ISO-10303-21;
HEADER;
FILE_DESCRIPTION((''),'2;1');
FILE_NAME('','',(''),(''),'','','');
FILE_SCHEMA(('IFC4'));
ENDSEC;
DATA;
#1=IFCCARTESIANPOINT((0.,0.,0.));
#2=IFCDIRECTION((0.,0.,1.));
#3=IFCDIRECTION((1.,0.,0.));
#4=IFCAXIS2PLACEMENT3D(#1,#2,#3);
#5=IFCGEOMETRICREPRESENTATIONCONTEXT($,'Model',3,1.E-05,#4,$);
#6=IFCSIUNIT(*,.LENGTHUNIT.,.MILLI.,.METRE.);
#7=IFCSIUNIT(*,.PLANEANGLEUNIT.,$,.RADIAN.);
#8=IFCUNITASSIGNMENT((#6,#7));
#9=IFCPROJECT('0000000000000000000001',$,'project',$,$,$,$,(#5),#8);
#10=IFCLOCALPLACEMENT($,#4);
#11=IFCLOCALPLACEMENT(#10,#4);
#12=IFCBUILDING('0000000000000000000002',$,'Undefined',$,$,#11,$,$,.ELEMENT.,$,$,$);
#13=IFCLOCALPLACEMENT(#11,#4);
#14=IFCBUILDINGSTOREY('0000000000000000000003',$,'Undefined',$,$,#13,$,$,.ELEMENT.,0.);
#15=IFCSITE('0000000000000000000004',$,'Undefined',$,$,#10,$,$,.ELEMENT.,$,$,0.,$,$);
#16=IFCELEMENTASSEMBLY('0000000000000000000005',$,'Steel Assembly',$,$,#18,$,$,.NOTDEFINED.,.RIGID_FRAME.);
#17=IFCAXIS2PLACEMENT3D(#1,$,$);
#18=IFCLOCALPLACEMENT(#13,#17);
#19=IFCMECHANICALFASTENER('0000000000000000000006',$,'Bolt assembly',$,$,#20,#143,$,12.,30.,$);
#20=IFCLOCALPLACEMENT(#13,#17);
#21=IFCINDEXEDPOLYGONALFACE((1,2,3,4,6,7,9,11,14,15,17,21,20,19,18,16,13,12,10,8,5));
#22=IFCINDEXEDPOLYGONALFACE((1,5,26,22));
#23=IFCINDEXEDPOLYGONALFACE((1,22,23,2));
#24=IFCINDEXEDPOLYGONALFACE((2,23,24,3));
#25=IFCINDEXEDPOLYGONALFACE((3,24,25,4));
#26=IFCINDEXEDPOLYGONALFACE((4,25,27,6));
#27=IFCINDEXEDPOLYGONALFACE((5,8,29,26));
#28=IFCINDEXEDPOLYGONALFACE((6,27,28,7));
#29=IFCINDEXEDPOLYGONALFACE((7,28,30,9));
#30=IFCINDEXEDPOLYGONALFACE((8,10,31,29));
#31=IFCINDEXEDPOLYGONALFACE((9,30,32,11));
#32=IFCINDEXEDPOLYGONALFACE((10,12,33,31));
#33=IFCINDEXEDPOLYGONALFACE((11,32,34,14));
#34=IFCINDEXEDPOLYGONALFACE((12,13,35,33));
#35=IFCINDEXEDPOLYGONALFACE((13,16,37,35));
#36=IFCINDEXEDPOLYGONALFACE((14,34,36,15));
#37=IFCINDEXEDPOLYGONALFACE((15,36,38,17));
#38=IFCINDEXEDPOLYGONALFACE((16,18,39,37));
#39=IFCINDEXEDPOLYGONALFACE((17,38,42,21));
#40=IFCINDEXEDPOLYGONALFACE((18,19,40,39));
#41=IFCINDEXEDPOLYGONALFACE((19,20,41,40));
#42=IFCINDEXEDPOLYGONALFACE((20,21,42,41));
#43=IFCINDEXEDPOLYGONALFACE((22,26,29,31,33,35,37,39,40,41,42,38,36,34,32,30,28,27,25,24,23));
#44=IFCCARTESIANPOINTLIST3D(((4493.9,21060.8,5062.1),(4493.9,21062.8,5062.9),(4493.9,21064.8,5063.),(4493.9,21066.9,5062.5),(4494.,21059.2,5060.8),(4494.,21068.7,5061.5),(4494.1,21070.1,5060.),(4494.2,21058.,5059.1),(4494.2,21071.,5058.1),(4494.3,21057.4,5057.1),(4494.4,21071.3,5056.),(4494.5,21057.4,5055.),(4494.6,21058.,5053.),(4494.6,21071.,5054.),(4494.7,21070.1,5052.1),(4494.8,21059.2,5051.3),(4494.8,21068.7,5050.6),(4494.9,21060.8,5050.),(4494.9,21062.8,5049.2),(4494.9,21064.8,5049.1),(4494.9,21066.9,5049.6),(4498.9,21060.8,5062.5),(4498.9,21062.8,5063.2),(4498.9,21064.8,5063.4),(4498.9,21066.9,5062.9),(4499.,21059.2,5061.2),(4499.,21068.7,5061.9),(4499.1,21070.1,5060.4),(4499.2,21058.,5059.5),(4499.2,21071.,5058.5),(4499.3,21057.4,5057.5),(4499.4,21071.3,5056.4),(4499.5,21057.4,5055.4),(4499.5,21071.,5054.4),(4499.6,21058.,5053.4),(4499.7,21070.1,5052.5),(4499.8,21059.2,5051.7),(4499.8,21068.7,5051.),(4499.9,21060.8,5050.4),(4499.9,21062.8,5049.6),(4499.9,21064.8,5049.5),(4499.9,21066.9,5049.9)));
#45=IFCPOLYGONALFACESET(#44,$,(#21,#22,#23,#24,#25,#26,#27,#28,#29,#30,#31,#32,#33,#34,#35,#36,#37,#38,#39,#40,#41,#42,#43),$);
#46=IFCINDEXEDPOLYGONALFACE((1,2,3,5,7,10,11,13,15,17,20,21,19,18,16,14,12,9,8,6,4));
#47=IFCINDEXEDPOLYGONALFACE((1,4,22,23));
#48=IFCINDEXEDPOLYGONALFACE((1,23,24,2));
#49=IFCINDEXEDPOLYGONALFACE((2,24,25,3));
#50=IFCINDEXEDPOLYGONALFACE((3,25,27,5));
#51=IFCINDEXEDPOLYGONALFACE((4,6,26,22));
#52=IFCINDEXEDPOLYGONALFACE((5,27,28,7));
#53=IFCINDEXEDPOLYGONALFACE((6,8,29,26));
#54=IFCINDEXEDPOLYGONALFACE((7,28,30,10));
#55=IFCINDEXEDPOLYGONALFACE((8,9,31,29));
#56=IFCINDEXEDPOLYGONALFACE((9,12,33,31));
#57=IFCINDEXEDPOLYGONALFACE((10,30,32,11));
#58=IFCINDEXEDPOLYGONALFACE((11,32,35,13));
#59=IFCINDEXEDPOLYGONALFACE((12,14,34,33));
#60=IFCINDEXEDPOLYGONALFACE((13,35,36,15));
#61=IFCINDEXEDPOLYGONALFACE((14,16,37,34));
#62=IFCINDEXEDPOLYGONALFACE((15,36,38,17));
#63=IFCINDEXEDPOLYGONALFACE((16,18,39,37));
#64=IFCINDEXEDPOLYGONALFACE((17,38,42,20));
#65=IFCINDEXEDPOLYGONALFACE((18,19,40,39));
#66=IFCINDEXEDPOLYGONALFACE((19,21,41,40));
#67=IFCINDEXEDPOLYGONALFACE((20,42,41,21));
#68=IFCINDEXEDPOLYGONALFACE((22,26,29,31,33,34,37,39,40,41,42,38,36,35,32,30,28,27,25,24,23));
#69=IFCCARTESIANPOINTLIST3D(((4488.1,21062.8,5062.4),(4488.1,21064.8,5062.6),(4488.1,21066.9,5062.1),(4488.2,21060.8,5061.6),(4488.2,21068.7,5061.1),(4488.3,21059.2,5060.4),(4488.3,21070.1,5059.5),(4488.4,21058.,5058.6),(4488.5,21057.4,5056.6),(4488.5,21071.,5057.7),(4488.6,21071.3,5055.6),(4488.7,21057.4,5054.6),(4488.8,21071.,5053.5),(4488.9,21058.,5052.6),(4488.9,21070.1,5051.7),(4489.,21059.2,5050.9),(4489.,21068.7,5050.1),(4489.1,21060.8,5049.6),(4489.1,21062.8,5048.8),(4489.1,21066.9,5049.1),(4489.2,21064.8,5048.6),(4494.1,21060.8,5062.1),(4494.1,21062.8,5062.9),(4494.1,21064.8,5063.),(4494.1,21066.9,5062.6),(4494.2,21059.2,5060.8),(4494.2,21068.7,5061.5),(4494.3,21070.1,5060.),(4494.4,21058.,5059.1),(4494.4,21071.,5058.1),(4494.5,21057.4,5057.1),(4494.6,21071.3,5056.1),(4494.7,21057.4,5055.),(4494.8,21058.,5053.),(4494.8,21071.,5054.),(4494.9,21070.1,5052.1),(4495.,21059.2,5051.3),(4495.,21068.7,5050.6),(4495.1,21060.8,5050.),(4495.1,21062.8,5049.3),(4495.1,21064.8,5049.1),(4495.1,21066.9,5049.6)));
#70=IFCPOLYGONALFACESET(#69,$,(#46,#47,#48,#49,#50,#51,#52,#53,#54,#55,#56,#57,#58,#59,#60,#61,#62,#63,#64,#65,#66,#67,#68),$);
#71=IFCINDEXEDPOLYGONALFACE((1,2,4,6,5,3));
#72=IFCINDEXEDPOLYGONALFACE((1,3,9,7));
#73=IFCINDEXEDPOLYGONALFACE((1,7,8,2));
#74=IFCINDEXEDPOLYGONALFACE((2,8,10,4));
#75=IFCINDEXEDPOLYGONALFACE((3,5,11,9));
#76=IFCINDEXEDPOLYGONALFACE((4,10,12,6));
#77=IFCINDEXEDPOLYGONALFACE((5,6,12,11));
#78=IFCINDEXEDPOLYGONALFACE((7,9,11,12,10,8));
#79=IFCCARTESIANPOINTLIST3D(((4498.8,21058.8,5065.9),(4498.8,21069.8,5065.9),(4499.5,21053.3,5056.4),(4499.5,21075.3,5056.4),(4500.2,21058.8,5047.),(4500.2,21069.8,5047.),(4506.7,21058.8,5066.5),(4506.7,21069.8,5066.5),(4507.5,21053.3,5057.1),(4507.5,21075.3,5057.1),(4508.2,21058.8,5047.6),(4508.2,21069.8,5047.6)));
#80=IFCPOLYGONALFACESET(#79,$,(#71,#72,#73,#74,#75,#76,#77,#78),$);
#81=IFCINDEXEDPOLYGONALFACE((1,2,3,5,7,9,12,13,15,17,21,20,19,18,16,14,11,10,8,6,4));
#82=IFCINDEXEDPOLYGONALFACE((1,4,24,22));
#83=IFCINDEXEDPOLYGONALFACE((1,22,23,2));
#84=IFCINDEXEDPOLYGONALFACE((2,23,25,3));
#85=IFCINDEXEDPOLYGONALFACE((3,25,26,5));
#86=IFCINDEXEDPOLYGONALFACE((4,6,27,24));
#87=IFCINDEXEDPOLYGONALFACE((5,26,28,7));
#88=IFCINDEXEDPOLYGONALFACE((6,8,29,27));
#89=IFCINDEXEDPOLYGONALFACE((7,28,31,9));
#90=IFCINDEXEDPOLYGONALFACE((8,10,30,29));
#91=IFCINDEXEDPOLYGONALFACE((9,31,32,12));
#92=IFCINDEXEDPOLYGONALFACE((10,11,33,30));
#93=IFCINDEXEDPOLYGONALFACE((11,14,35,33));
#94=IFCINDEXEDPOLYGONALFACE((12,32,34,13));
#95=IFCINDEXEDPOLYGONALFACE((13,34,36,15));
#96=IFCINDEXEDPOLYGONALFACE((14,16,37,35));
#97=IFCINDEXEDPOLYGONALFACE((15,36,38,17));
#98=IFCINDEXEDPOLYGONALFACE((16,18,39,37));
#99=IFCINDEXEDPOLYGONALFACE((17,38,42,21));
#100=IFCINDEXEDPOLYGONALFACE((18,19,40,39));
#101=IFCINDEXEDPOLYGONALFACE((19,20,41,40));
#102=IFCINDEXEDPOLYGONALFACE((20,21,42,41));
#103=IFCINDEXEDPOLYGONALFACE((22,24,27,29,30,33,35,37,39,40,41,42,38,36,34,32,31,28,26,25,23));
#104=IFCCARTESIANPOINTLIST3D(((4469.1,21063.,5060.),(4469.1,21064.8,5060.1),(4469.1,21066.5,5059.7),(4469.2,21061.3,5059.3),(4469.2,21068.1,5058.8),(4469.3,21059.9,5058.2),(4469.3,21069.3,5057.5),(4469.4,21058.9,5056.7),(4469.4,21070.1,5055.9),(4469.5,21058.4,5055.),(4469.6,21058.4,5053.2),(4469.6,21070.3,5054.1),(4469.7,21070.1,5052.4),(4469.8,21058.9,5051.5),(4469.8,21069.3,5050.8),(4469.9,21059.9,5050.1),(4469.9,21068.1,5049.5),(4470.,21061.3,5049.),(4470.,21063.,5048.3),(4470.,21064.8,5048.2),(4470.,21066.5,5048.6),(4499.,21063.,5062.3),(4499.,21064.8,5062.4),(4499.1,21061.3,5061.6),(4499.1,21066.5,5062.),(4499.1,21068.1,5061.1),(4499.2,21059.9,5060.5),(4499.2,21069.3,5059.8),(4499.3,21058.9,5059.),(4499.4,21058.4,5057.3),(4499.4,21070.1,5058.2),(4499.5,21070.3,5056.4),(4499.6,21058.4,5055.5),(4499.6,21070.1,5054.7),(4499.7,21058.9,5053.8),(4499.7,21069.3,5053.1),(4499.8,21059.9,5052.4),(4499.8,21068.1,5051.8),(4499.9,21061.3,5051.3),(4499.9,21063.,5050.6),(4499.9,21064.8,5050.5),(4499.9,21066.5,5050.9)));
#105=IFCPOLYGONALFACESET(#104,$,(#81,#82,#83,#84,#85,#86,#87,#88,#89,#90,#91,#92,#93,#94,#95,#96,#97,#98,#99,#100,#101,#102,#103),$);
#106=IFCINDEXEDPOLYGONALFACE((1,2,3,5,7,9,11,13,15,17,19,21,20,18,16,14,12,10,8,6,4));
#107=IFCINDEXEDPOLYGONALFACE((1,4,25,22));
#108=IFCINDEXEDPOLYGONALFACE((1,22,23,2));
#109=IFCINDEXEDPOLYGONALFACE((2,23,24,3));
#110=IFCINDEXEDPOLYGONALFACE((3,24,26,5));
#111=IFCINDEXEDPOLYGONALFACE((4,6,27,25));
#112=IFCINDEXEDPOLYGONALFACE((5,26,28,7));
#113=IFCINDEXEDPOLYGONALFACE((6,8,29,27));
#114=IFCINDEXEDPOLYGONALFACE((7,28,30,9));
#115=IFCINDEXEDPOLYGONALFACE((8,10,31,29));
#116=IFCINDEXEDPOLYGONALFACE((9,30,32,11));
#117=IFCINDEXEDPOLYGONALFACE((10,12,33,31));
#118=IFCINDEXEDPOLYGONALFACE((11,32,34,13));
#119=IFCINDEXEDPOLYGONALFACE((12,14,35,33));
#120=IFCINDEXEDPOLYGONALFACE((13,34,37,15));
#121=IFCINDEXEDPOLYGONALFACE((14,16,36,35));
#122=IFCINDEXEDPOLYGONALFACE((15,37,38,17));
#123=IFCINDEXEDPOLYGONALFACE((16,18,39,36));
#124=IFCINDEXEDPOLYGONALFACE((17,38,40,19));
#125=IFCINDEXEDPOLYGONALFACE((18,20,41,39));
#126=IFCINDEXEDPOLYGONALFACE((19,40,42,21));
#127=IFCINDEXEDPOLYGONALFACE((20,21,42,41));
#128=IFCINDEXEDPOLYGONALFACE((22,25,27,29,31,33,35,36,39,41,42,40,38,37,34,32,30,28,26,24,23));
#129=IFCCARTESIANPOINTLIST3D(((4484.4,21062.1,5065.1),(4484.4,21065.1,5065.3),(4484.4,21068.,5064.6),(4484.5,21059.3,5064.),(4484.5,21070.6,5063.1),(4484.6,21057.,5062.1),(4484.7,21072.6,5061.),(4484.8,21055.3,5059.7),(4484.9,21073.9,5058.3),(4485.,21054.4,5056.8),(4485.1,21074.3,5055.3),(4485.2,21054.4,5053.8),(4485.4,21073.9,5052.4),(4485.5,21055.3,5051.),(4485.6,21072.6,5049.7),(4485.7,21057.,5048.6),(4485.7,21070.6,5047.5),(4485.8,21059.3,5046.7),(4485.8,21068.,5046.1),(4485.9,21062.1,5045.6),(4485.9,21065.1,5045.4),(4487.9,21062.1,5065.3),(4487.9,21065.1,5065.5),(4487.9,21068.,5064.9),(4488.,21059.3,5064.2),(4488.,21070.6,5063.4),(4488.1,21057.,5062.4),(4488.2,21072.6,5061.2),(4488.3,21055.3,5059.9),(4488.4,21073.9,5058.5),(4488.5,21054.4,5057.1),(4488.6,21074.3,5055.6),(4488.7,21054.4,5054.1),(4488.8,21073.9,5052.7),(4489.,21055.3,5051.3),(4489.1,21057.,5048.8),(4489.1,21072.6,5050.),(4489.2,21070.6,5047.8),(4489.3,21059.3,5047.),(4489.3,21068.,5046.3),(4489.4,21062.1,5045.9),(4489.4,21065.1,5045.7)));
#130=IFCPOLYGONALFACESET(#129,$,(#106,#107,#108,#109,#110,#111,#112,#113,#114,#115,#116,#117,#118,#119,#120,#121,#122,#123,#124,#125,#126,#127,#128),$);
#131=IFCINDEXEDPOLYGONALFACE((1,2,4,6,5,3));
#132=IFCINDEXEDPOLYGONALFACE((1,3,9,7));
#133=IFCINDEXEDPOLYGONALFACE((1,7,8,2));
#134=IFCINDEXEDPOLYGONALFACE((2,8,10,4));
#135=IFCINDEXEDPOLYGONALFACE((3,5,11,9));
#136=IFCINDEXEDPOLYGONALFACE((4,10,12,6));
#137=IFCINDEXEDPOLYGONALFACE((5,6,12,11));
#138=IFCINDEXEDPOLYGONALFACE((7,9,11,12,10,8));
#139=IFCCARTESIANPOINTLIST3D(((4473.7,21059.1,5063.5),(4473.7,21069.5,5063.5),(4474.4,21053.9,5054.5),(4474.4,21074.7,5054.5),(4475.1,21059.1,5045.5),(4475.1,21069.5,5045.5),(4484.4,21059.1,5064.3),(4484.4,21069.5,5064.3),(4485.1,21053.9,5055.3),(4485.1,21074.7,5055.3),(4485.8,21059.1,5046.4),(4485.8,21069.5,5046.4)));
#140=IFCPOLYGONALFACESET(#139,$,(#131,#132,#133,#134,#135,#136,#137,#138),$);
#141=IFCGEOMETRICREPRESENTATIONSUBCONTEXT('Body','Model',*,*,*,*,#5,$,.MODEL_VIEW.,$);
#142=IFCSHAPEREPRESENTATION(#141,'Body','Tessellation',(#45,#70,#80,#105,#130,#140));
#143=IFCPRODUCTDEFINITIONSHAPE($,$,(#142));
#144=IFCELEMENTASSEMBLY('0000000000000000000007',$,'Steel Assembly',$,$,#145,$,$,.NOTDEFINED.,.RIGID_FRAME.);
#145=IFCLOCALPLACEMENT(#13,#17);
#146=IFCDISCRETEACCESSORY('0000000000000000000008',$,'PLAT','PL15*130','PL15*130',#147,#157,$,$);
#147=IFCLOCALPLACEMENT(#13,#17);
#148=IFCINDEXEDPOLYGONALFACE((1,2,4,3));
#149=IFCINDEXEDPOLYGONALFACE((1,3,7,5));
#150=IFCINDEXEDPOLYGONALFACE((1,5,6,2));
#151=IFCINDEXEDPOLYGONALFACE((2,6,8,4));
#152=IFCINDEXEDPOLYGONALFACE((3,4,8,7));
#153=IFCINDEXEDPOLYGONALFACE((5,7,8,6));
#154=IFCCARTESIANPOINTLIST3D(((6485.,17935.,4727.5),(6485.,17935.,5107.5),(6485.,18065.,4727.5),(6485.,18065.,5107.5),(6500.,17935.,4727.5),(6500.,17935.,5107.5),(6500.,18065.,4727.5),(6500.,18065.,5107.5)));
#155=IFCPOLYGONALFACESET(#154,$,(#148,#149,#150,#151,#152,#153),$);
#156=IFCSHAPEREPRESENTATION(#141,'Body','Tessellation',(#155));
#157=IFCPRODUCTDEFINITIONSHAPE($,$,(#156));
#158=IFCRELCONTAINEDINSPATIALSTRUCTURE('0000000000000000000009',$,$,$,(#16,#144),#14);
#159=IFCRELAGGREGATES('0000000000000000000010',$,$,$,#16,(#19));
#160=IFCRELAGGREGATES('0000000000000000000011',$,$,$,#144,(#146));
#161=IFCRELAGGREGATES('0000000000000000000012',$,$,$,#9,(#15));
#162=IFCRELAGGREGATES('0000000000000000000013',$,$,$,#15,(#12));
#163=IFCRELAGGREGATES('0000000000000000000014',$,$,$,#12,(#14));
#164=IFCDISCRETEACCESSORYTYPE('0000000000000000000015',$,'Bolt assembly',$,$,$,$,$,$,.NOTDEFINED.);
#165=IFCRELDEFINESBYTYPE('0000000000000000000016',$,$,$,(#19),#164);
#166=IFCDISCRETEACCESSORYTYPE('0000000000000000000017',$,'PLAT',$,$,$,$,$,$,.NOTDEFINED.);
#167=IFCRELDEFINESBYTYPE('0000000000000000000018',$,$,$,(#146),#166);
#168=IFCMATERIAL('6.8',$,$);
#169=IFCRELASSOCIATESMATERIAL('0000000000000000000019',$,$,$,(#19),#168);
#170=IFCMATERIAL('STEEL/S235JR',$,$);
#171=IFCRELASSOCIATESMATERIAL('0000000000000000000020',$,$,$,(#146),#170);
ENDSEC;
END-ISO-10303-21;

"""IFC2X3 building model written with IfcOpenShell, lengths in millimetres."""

from ifc_helpers import new_model, si_unit, frame, origin_with_axes, origin_2d_with_axis, place, context, subcontext, project, spatial, polyline, circle, outline, extrude, source, transform, mapped, material, type_object, element, aggregate, save


model = new_model("IFC2X3")

# Units and contexts
model_context = context("Model", 3, precision=1e-05, world=origin_with_axes())
body_context = subcontext(model_context, "Body", "Model", "MODEL_VIEW")
ifc_project = project(units=[si_unit("LENGTHUNIT", "METRE", prefix="MILLI"), si_unit("PLANEANGLEUNIT", "RADIAN")], contexts=[model_context])

# Site, building, storey
site_placement = place(None, origin_with_axes())
site = spatial("IfcSite", under=ifc_project, at=site_placement, Name="Undefined", CompositionType="ELEMENT", RefElevation=0.0)
building_placement = place(site_placement, origin_with_axes())
building = spatial("IfcBuilding", under=site, at=building_placement, Name="Undefined", CompositionType="ELEMENT")
storey_placement = place(building_placement, origin_with_axes())
storey = spatial("IfcBuildingStorey", under=building, at=storey_placement, Name="Undefined", CompositionType="ELEMENT", Elevation=0.0)

# Shared definitions
ifc_material_1 = material(Name="STEEL/S235JR")

# Shared definitions
ifc_material_2 = material(Name="6.8")
discrete_accessory_type_1 = type_object("IfcDiscreteAccessoryType", Name="Bolt assembly")

# Element assembly, mechanical fastener
assembly_1_placement = place(storey_placement, origin_with_axes())
assembly_1 = element("IfcElementAssembly", 1, at=assembly_1_placement, inside=storey, Name="Steel Assembly", AssemblyPlace="NOTDEFINED", PredefinedType="RIGID_FRAME")
shared_shape_1 = source(origin_with_axes(), body_context, "Body", "SweptSolid", [
    extrude(circle(Radius=7.0, at=origin_2d_with_axis()), frame((0.0, -4.9, 0.0), z_axis=(0.0, 1.0, 0.0), x_axis=(1.0, 0.0, 0.0)), (0.0, 0.0, 1.0), 5.0),
    extrude(circle(Radius=7.0, at=origin_2d_with_axis()), frame((0.0, -0.1, 0.0), z_axis=(0.0, 1.0, 0.0), x_axis=(1.0, 0.0, 0.0)), (0.0, 0.0, 1.0), 6.0),
    extrude(outline(polyline([(11.0, 0.0), (5.5, 9.5), (-5.5, 9.5), (-11.0, 0.0), (-5.5, -9.5), (5.5, -9.5), (11.0, 0.0)])), frame((0.0, -13.0, 0.0), z_axis=(0.0, 1.0, 0.0), x_axis=(1.0, 0.0, 0.0)), (0.0, 0.0, 1.0), 8.0),
    extrude(circle(Radius=6.0, at=origin_2d_with_axis()), frame((0.0, -5.0, 0.0), z_axis=(0.0, 1.0, 0.0), x_axis=(1.0, 0.0, 0.0)), (0.0, 0.0, 1.0), 30.0),
    extrude(circle(Radius=10.0, at=origin_2d_with_axis()), frame((0.0, 5.9, 0.0), z_axis=(0.0, 1.0, 0.0), x_axis=(1.0, 0.0, 0.0)), (0.0, 0.0, 1.0), 3.5),
    extrude(outline(polyline([(10.4, 0.0), (5.2, 9.0), (-5.2, 9.0), (-10.4, 0.0), (-5.2, -9.0), (5.2, -9.0), (10.4, 0.0)])), frame((0.0, 9.4, 0.0), z_axis=(0.0, 1.0, 0.0), x_axis=(1.0, 0.0, 0.0)), (0.0, 0.0, 1.0), 10.8),
])
mechanical_fastener_1_placement = place(assembly_1_placement, frame((4494.5, 21064.3, 5056.1), z_axis=(-0.076696, 0.0, 0.997054), x_axis=(0.0, 1.0, 0.0)))
mechanical_fastener_1 = element("IfcMechanicalFastener", 2, at=mechanical_fastener_1_placement, type_object=discrete_accessory_type_1, material=ifc_material_2, Name="Bolt assembly", NominalDiameter=12.0, NominalLength=30.0, context=body_context, shape_type="MappedRepresentation", body=[
    mapped(shared_shape_1, transform((0.0, 0.0, 0.0))),
])
aggregate(assembly_1, [mechanical_fastener_1])

# Element assembly, discrete accessory
assembly_2_placement = place(storey_placement, origin_with_axes())
assembly_2 = element("IfcElementAssembly", 3, at=assembly_2_placement, inside=storey, Name="Steel Assembly", AssemblyPlace="NOTDEFINED", PredefinedType="RIGID_FRAME")
discrete_accessory_type_2 = type_object("IfcDiscreteAccessoryType", Name="PLAT")
discrete_accessory_placement = place(assembly_2_placement, frame((6492.5, 18000.0, 5107.5), z_axis=(-1.0, 0.0, 0.0), x_axis=(0.0, 0.0, -1.0)))
discrete_accessory = element("IfcDiscreteAccessory", 4, at=discrete_accessory_placement, type_object=discrete_accessory_type_2, material=ifc_material_1, Name="PLAT", Description="PL15*130", ObjectType="PL15*130", context=body_context, shape_type="SweptSolid", body=[
    extrude(outline(polyline([(380.0, 65.0), (380.0, -65.0), (0.0, -65.0), (0.0, 65.0), (380.0, 65.0)])), frame((0.0, 0.0, -7.5), z_axis=(0.0, 0.0, 1.0), x_axis=(1.0, 0.0, 0.0)), (0.0, 0.0, 1.0), 15.0),
])
aggregate(assembly_2, [discrete_accessory])

save(model, "model.ifc")
